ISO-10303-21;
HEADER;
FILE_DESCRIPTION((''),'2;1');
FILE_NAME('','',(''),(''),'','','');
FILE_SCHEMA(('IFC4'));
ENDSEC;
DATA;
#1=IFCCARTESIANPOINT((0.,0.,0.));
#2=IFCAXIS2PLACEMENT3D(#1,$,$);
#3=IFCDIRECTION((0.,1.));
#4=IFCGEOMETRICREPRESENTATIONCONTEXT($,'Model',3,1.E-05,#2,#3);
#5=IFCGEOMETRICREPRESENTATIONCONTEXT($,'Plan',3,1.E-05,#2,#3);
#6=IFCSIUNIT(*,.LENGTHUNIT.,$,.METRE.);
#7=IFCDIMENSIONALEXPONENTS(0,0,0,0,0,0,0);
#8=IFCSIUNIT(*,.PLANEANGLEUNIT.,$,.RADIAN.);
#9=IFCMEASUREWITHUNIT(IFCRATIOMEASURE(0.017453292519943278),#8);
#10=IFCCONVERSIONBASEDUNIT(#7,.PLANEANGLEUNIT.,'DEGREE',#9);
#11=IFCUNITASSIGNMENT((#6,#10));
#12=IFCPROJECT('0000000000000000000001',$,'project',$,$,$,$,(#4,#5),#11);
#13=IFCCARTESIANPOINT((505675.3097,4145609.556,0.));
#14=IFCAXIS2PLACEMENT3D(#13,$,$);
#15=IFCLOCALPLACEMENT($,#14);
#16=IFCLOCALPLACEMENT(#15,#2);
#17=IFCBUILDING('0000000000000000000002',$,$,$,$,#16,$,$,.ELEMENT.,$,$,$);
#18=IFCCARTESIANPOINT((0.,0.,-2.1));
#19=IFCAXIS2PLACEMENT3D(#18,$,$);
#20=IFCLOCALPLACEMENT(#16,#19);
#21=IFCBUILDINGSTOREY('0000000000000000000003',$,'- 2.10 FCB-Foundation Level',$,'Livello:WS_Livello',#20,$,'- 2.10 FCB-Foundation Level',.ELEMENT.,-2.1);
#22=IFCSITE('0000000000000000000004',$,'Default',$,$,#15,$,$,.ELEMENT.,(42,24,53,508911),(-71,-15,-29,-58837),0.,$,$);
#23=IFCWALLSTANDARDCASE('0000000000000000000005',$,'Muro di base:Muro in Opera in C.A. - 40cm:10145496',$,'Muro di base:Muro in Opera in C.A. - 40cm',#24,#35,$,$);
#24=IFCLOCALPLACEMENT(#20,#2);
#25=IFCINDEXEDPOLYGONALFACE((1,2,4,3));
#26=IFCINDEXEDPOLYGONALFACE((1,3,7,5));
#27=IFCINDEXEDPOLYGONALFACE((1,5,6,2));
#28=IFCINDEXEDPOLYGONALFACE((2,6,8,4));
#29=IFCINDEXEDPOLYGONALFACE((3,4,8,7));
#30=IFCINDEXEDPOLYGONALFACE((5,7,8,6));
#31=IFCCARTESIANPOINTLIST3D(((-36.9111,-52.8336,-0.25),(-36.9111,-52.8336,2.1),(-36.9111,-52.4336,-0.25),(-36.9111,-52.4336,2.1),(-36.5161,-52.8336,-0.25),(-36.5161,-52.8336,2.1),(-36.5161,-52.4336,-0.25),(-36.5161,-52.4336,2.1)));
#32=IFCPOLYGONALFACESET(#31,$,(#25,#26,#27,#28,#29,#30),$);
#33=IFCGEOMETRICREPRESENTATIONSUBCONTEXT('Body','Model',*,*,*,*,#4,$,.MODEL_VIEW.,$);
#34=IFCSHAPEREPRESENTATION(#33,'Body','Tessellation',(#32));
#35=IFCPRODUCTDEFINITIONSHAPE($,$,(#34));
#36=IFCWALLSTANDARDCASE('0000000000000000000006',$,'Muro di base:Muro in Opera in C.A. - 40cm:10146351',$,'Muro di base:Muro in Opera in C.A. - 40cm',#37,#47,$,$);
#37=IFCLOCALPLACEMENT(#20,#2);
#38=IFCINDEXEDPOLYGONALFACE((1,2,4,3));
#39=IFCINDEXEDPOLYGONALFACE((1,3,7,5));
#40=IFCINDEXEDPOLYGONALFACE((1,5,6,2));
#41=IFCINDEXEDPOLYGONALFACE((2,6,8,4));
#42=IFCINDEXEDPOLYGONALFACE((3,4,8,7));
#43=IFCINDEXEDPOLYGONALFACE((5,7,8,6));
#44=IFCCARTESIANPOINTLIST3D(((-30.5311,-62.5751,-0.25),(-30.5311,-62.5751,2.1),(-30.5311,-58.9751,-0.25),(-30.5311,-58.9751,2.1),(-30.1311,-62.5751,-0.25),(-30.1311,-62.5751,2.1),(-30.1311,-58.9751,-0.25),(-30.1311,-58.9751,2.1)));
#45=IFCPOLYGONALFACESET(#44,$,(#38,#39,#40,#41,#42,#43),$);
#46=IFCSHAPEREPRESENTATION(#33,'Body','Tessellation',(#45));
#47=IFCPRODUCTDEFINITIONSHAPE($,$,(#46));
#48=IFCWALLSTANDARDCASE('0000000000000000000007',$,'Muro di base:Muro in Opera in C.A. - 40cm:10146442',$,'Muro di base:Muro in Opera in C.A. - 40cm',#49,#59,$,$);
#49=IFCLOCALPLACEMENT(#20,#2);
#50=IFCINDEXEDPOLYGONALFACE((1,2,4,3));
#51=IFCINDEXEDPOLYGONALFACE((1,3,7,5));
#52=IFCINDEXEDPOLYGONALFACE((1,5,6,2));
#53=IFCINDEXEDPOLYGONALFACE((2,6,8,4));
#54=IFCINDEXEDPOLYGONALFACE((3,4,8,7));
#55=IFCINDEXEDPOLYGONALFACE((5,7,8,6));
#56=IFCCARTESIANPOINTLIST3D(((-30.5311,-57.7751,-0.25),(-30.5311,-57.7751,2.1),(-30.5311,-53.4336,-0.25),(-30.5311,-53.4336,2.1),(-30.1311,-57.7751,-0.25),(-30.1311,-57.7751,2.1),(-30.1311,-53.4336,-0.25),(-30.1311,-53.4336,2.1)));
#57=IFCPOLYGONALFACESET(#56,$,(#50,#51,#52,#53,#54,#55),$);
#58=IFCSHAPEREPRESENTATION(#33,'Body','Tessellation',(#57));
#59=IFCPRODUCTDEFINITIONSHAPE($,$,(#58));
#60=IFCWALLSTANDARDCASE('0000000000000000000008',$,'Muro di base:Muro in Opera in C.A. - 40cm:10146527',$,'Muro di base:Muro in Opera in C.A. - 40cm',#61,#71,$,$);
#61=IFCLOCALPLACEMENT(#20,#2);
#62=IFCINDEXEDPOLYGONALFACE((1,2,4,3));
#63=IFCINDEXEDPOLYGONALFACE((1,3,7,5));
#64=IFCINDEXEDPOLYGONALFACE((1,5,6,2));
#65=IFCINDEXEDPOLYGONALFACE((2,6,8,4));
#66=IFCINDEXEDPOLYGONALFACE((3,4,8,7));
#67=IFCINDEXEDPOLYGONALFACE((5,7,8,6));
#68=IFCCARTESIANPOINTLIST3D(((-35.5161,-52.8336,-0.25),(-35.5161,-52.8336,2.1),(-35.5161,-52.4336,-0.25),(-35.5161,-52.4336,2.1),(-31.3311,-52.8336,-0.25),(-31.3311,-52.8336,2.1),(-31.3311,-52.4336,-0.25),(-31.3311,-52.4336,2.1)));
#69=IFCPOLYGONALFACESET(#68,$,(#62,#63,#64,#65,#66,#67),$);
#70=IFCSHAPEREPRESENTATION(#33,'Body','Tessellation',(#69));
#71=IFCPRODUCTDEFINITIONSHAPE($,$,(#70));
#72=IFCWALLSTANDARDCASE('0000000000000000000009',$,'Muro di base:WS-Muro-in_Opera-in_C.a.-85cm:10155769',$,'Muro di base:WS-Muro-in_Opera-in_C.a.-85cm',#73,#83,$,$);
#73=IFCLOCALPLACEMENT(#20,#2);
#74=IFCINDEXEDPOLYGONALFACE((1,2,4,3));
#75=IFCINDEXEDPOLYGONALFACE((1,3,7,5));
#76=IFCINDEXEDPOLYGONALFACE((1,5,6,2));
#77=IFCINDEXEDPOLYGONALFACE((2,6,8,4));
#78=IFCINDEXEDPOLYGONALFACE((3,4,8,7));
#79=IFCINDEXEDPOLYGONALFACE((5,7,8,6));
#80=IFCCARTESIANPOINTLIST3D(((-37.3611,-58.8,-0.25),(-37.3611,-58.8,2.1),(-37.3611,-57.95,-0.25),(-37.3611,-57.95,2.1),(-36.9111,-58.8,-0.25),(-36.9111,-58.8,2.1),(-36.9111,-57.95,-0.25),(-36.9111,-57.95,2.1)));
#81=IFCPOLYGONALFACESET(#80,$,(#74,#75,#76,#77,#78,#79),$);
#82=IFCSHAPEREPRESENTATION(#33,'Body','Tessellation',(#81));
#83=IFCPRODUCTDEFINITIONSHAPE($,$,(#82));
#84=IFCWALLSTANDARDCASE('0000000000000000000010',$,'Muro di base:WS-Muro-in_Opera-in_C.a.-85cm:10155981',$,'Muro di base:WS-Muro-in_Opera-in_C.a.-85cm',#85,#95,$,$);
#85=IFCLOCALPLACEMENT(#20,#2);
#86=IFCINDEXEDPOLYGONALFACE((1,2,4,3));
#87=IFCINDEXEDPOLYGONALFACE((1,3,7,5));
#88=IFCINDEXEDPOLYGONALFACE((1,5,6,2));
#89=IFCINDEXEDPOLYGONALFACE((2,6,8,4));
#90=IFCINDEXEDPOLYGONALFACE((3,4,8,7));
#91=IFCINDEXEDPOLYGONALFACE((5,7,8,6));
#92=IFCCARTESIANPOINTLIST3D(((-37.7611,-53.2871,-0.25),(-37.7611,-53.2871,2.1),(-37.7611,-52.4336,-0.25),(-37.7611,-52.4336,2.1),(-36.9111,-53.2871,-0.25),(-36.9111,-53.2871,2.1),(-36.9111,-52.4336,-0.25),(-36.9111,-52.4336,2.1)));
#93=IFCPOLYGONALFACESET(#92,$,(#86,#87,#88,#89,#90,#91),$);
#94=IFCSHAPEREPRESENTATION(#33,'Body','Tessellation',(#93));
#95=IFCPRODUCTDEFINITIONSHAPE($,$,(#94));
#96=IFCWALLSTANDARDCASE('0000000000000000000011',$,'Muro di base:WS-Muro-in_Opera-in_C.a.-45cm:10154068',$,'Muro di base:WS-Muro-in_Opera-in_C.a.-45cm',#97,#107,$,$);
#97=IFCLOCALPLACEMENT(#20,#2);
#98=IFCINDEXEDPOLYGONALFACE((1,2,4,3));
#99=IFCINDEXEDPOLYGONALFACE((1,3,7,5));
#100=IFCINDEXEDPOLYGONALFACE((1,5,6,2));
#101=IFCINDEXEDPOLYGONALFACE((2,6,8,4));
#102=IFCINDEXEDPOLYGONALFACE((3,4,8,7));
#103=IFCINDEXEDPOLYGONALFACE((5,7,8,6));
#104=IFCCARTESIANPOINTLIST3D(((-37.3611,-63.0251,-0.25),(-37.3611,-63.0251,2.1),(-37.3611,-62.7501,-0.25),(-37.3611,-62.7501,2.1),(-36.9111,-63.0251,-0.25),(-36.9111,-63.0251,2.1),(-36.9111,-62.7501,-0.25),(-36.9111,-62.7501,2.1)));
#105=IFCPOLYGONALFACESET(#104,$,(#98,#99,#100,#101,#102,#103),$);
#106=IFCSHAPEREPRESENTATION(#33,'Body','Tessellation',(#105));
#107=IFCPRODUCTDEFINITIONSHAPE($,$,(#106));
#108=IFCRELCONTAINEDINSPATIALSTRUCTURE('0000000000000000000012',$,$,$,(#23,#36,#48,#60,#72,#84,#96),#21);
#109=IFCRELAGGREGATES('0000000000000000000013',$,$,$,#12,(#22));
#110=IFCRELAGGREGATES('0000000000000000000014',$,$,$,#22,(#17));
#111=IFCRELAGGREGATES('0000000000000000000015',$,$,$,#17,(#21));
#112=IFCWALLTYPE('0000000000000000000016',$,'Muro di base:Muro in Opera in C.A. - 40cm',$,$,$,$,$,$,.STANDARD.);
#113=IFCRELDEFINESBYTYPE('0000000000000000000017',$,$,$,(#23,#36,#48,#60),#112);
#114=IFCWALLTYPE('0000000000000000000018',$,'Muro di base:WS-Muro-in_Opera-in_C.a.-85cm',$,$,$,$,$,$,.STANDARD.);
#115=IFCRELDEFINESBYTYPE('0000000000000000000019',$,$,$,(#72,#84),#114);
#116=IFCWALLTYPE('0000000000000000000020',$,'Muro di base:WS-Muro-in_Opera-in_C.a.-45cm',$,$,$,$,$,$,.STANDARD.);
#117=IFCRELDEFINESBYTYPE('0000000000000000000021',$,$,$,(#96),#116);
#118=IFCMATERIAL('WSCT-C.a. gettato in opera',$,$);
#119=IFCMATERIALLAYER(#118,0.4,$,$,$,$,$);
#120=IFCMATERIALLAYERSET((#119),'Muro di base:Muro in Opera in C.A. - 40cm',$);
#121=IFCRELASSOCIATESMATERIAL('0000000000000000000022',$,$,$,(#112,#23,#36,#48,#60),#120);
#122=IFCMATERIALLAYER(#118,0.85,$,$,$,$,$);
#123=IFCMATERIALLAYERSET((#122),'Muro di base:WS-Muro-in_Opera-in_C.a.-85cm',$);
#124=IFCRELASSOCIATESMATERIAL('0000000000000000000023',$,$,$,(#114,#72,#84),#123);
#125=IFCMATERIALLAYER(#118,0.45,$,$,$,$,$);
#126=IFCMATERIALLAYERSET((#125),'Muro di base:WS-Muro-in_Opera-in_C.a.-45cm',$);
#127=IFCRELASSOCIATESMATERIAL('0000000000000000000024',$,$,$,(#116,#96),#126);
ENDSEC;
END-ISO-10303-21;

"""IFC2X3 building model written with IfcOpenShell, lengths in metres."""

from ifc_helpers import new_model, entity, si_unit, converted_unit, direction, frame, frame_2d, origin, place, context, subcontext, project, spatial, rectangle, extrude, material, layer, layer_set, layer_usage, type_object, element, save


model = new_model("IFC2X3")

# Units and contexts
model_context = context("Model", 3, precision=1e-05, world=origin(), true_north=direction((0.0, 1.0)))
plan_context = context("Plan", 3, precision=1e-05, world=origin(), true_north=direction((0.0, 1.0)))
body_context = subcontext(model_context, "Body", "Model", "MODEL_VIEW")
ifc_project = project(units=[si_unit("LENGTHUNIT", "METRE"), converted_unit("PLANEANGLEUNIT", "DEGREE", entity("IfcRatioMeasure", 0.017453292519943278), si_unit("PLANEANGLEUNIT", "RADIAN"), dimensions=[0, 0, 0, 0, 0, 0, 0])], contexts=[model_context, plan_context])

# Site, building, storey
site_placement = place(None, frame((505675.3097, 4145609.556, 0.0)))
site = spatial("IfcSite", under=ifc_project, at=site_placement, Name="Default", CompositionType="ELEMENT", RefLatitude=(42, 24, 53, 508911), RefLongitude=(-71, -15, -29, -58837), RefElevation=0.0)
building_placement = place(site_placement, origin())
building = spatial("IfcBuilding", under=site, at=building_placement, CompositionType="ELEMENT")
storey_placement = place(building_placement, frame((0.0, 0.0, -2.1)))
storey = spatial("IfcBuildingStorey", under=building, at=storey_placement, Name="- 2.10 FCB-Foundation Level", ObjectType="Livello:WS_Livello", LongName="- 2.10 FCB-Foundation Level", CompositionType="ELEMENT", Elevation=-2.1)

# Shared definitions
ifc_material = material(Name="WSCT-C.a. gettato in opera")

# Walls
ifc_layer_1 = layer(ifc_material, 0.4)
ifc_layer_set_1 = layer_set([ifc_layer_1], Name="Muro di base:Muro in Opera in C.A. - 40cm")
ifc_layer_usage_1 = layer_usage(ifc_layer_set_1, "AXIS2", "NEGATIVE", 0.2)
wall_type_1 = type_object("IfcWallType", Name="Muro di base:Muro in Opera in C.A. - 40cm", PredefinedType="STANDARD", material=ifc_layer_set_1)
wall_1_placement = place(storey_placement, frame((-36.9111, -52.6336, -0.25)))
element("IfcWallStandardCase", 1, at=wall_1_placement, inside=storey, type_object=wall_type_1, material=ifc_layer_usage_1, Name="Muro di base:Muro in Opera in C.A. - 40cm:10145496", ObjectType="Muro di base:Muro in Opera in C.A. - 40cm", context=body_context, shape_type="SweptSolid", body=[
    extrude(rectangle(XDim=0.395, YDim=0.4, at=frame_2d((0.1975, 0.0), x_axis=(-1.0, 0.0))), origin(), (0.0, 0.0, 1.0), 2.35),
])
wall_2_placement = place(storey_placement, frame((-30.3311, -62.5751, -0.25), z_axis=(0.0, 0.0, 1.0), x_axis=(0.0, 1.0, 0.0)))
element("IfcWallStandardCase", 2, at=wall_2_placement, inside=storey, type_object=wall_type_1, material=ifc_layer_usage_1, Name="Muro di base:Muro in Opera in C.A. - 40cm:10146351", ObjectType="Muro di base:Muro in Opera in C.A. - 40cm", context=body_context, shape_type="SweptSolid", body=[
    extrude(rectangle(XDim=3.6, YDim=0.4, at=frame_2d((1.8, 0.0), x_axis=(-1.0, 0.0))), origin(), (0.0, 0.0, 1.0), 2.35),
])
wall_3_placement = place(storey_placement, frame((-30.3311, -57.7751, -0.25), z_axis=(0.0, 0.0, 1.0), x_axis=(0.0, 1.0, 0.0)))
element("IfcWallStandardCase", 3, at=wall_3_placement, inside=storey, type_object=wall_type_1, material=ifc_layer_usage_1, Name="Muro di base:Muro in Opera in C.A. - 40cm:10146442", ObjectType="Muro di base:Muro in Opera in C.A. - 40cm", context=body_context, shape_type="SweptSolid", body=[
    extrude(rectangle(XDim=4.3415, YDim=0.4, at=frame_2d((2.1707, 0.0), x_axis=(-1.0, 0.0))), origin(), (0.0, 0.0, 1.0), 2.35),
])
wall_4_placement = place(storey_placement, frame((-35.5161, -52.6336, -0.25)))
element("IfcWallStandardCase", 4, at=wall_4_placement, inside=storey, type_object=wall_type_1, material=ifc_layer_usage_1, Name="Muro di base:Muro in Opera in C.A. - 40cm:10146527", ObjectType="Muro di base:Muro in Opera in C.A. - 40cm", context=body_context, shape_type="SweptSolid", body=[
    extrude(rectangle(XDim=4.1851, YDim=0.4, at=frame_2d((2.0925, 0.0), x_axis=(-1.0, 0.0))), origin(), (0.0, 0.0, 1.0), 2.35),
])
ifc_layer_2 = layer(ifc_material, 0.85)
ifc_layer_set_2 = layer_set([ifc_layer_2], Name="Muro di base:WS-Muro-in_Opera-in_C.a.-85cm")
ifc_layer_usage_2 = layer_usage(ifc_layer_set_2, "AXIS2", "NEGATIVE", 0.425)
wall_type_2 = type_object("IfcWallType", Name="Muro di base:WS-Muro-in_Opera-in_C.a.-85cm", PredefinedType="STANDARD", material=ifc_layer_set_2)
wall_5_placement = place(storey_placement, frame((-37.3611, -58.375, -0.25)))
element("IfcWallStandardCase", 5, at=wall_5_placement, inside=storey, type_object=wall_type_2, material=ifc_layer_usage_2, Name="Muro di base:WS-Muro-in_Opera-in_C.a.-85cm:10155769", ObjectType="Muro di base:WS-Muro-in_Opera-in_C.a.-85cm", context=body_context, shape_type="SweptSolid", body=[
    extrude(rectangle(XDim=0.45, YDim=0.85, at=frame_2d((0.225, 0.0), x_axis=(-1.0, 0.0))), origin(), (0.0, 0.0, 1.0), 2.35),
])
wall_6_placement = place(storey_placement, frame((-37.3361, -53.2871, -0.25), z_axis=(0.0, 0.0, 1.0), x_axis=(0.0, 1.0, 0.0)))
element("IfcWallStandardCase", 6, at=wall_6_placement, inside=storey, type_object=wall_type_2, material=ifc_layer_usage_2, Name="Muro di base:WS-Muro-in_Opera-in_C.a.-85cm:10155981", ObjectType="Muro di base:WS-Muro-in_Opera-in_C.a.-85cm", context=body_context, shape_type="SweptSolid", body=[
    extrude(rectangle(XDim=0.8534, YDim=0.85, at=frame_2d((0.4267, 0.0), x_axis=(-1.0, 0.0))), origin(), (0.0, 0.0, 1.0), 2.35),
])
ifc_layer_3 = layer(ifc_material, 0.45)
ifc_layer_set_3 = layer_set([ifc_layer_3], Name="Muro di base:WS-Muro-in_Opera-in_C.a.-45cm")
ifc_layer_usage_3 = layer_usage(ifc_layer_set_3, "AXIS2", "NEGATIVE", 0.225)
wall_type_3 = type_object("IfcWallType", Name="Muro di base:WS-Muro-in_Opera-in_C.a.-45cm", PredefinedType="STANDARD", material=ifc_layer_set_3)
wall_7_placement = place(storey_placement, frame((-37.1361, -62.7501, -0.25), z_axis=(0.0, 0.0, 1.0), x_axis=(0.0, -1.0, 0.0)))
element("IfcWallStandardCase", 7, at=wall_7_placement, inside=storey, type_object=wall_type_3, material=ifc_layer_usage_3, Name="Muro di base:WS-Muro-in_Opera-in_C.a.-45cm:10154068", ObjectType="Muro di base:WS-Muro-in_Opera-in_C.a.-45cm", context=body_context, shape_type="SweptSolid", body=[
    extrude(rectangle(XDim=0.275, YDim=0.45, at=frame_2d((0.1375, 0.0), x_axis=(-1.0, 0.0))), origin(), (0.0, 0.0, 1.0), 2.35),
])

save(model, "model.ifc")
